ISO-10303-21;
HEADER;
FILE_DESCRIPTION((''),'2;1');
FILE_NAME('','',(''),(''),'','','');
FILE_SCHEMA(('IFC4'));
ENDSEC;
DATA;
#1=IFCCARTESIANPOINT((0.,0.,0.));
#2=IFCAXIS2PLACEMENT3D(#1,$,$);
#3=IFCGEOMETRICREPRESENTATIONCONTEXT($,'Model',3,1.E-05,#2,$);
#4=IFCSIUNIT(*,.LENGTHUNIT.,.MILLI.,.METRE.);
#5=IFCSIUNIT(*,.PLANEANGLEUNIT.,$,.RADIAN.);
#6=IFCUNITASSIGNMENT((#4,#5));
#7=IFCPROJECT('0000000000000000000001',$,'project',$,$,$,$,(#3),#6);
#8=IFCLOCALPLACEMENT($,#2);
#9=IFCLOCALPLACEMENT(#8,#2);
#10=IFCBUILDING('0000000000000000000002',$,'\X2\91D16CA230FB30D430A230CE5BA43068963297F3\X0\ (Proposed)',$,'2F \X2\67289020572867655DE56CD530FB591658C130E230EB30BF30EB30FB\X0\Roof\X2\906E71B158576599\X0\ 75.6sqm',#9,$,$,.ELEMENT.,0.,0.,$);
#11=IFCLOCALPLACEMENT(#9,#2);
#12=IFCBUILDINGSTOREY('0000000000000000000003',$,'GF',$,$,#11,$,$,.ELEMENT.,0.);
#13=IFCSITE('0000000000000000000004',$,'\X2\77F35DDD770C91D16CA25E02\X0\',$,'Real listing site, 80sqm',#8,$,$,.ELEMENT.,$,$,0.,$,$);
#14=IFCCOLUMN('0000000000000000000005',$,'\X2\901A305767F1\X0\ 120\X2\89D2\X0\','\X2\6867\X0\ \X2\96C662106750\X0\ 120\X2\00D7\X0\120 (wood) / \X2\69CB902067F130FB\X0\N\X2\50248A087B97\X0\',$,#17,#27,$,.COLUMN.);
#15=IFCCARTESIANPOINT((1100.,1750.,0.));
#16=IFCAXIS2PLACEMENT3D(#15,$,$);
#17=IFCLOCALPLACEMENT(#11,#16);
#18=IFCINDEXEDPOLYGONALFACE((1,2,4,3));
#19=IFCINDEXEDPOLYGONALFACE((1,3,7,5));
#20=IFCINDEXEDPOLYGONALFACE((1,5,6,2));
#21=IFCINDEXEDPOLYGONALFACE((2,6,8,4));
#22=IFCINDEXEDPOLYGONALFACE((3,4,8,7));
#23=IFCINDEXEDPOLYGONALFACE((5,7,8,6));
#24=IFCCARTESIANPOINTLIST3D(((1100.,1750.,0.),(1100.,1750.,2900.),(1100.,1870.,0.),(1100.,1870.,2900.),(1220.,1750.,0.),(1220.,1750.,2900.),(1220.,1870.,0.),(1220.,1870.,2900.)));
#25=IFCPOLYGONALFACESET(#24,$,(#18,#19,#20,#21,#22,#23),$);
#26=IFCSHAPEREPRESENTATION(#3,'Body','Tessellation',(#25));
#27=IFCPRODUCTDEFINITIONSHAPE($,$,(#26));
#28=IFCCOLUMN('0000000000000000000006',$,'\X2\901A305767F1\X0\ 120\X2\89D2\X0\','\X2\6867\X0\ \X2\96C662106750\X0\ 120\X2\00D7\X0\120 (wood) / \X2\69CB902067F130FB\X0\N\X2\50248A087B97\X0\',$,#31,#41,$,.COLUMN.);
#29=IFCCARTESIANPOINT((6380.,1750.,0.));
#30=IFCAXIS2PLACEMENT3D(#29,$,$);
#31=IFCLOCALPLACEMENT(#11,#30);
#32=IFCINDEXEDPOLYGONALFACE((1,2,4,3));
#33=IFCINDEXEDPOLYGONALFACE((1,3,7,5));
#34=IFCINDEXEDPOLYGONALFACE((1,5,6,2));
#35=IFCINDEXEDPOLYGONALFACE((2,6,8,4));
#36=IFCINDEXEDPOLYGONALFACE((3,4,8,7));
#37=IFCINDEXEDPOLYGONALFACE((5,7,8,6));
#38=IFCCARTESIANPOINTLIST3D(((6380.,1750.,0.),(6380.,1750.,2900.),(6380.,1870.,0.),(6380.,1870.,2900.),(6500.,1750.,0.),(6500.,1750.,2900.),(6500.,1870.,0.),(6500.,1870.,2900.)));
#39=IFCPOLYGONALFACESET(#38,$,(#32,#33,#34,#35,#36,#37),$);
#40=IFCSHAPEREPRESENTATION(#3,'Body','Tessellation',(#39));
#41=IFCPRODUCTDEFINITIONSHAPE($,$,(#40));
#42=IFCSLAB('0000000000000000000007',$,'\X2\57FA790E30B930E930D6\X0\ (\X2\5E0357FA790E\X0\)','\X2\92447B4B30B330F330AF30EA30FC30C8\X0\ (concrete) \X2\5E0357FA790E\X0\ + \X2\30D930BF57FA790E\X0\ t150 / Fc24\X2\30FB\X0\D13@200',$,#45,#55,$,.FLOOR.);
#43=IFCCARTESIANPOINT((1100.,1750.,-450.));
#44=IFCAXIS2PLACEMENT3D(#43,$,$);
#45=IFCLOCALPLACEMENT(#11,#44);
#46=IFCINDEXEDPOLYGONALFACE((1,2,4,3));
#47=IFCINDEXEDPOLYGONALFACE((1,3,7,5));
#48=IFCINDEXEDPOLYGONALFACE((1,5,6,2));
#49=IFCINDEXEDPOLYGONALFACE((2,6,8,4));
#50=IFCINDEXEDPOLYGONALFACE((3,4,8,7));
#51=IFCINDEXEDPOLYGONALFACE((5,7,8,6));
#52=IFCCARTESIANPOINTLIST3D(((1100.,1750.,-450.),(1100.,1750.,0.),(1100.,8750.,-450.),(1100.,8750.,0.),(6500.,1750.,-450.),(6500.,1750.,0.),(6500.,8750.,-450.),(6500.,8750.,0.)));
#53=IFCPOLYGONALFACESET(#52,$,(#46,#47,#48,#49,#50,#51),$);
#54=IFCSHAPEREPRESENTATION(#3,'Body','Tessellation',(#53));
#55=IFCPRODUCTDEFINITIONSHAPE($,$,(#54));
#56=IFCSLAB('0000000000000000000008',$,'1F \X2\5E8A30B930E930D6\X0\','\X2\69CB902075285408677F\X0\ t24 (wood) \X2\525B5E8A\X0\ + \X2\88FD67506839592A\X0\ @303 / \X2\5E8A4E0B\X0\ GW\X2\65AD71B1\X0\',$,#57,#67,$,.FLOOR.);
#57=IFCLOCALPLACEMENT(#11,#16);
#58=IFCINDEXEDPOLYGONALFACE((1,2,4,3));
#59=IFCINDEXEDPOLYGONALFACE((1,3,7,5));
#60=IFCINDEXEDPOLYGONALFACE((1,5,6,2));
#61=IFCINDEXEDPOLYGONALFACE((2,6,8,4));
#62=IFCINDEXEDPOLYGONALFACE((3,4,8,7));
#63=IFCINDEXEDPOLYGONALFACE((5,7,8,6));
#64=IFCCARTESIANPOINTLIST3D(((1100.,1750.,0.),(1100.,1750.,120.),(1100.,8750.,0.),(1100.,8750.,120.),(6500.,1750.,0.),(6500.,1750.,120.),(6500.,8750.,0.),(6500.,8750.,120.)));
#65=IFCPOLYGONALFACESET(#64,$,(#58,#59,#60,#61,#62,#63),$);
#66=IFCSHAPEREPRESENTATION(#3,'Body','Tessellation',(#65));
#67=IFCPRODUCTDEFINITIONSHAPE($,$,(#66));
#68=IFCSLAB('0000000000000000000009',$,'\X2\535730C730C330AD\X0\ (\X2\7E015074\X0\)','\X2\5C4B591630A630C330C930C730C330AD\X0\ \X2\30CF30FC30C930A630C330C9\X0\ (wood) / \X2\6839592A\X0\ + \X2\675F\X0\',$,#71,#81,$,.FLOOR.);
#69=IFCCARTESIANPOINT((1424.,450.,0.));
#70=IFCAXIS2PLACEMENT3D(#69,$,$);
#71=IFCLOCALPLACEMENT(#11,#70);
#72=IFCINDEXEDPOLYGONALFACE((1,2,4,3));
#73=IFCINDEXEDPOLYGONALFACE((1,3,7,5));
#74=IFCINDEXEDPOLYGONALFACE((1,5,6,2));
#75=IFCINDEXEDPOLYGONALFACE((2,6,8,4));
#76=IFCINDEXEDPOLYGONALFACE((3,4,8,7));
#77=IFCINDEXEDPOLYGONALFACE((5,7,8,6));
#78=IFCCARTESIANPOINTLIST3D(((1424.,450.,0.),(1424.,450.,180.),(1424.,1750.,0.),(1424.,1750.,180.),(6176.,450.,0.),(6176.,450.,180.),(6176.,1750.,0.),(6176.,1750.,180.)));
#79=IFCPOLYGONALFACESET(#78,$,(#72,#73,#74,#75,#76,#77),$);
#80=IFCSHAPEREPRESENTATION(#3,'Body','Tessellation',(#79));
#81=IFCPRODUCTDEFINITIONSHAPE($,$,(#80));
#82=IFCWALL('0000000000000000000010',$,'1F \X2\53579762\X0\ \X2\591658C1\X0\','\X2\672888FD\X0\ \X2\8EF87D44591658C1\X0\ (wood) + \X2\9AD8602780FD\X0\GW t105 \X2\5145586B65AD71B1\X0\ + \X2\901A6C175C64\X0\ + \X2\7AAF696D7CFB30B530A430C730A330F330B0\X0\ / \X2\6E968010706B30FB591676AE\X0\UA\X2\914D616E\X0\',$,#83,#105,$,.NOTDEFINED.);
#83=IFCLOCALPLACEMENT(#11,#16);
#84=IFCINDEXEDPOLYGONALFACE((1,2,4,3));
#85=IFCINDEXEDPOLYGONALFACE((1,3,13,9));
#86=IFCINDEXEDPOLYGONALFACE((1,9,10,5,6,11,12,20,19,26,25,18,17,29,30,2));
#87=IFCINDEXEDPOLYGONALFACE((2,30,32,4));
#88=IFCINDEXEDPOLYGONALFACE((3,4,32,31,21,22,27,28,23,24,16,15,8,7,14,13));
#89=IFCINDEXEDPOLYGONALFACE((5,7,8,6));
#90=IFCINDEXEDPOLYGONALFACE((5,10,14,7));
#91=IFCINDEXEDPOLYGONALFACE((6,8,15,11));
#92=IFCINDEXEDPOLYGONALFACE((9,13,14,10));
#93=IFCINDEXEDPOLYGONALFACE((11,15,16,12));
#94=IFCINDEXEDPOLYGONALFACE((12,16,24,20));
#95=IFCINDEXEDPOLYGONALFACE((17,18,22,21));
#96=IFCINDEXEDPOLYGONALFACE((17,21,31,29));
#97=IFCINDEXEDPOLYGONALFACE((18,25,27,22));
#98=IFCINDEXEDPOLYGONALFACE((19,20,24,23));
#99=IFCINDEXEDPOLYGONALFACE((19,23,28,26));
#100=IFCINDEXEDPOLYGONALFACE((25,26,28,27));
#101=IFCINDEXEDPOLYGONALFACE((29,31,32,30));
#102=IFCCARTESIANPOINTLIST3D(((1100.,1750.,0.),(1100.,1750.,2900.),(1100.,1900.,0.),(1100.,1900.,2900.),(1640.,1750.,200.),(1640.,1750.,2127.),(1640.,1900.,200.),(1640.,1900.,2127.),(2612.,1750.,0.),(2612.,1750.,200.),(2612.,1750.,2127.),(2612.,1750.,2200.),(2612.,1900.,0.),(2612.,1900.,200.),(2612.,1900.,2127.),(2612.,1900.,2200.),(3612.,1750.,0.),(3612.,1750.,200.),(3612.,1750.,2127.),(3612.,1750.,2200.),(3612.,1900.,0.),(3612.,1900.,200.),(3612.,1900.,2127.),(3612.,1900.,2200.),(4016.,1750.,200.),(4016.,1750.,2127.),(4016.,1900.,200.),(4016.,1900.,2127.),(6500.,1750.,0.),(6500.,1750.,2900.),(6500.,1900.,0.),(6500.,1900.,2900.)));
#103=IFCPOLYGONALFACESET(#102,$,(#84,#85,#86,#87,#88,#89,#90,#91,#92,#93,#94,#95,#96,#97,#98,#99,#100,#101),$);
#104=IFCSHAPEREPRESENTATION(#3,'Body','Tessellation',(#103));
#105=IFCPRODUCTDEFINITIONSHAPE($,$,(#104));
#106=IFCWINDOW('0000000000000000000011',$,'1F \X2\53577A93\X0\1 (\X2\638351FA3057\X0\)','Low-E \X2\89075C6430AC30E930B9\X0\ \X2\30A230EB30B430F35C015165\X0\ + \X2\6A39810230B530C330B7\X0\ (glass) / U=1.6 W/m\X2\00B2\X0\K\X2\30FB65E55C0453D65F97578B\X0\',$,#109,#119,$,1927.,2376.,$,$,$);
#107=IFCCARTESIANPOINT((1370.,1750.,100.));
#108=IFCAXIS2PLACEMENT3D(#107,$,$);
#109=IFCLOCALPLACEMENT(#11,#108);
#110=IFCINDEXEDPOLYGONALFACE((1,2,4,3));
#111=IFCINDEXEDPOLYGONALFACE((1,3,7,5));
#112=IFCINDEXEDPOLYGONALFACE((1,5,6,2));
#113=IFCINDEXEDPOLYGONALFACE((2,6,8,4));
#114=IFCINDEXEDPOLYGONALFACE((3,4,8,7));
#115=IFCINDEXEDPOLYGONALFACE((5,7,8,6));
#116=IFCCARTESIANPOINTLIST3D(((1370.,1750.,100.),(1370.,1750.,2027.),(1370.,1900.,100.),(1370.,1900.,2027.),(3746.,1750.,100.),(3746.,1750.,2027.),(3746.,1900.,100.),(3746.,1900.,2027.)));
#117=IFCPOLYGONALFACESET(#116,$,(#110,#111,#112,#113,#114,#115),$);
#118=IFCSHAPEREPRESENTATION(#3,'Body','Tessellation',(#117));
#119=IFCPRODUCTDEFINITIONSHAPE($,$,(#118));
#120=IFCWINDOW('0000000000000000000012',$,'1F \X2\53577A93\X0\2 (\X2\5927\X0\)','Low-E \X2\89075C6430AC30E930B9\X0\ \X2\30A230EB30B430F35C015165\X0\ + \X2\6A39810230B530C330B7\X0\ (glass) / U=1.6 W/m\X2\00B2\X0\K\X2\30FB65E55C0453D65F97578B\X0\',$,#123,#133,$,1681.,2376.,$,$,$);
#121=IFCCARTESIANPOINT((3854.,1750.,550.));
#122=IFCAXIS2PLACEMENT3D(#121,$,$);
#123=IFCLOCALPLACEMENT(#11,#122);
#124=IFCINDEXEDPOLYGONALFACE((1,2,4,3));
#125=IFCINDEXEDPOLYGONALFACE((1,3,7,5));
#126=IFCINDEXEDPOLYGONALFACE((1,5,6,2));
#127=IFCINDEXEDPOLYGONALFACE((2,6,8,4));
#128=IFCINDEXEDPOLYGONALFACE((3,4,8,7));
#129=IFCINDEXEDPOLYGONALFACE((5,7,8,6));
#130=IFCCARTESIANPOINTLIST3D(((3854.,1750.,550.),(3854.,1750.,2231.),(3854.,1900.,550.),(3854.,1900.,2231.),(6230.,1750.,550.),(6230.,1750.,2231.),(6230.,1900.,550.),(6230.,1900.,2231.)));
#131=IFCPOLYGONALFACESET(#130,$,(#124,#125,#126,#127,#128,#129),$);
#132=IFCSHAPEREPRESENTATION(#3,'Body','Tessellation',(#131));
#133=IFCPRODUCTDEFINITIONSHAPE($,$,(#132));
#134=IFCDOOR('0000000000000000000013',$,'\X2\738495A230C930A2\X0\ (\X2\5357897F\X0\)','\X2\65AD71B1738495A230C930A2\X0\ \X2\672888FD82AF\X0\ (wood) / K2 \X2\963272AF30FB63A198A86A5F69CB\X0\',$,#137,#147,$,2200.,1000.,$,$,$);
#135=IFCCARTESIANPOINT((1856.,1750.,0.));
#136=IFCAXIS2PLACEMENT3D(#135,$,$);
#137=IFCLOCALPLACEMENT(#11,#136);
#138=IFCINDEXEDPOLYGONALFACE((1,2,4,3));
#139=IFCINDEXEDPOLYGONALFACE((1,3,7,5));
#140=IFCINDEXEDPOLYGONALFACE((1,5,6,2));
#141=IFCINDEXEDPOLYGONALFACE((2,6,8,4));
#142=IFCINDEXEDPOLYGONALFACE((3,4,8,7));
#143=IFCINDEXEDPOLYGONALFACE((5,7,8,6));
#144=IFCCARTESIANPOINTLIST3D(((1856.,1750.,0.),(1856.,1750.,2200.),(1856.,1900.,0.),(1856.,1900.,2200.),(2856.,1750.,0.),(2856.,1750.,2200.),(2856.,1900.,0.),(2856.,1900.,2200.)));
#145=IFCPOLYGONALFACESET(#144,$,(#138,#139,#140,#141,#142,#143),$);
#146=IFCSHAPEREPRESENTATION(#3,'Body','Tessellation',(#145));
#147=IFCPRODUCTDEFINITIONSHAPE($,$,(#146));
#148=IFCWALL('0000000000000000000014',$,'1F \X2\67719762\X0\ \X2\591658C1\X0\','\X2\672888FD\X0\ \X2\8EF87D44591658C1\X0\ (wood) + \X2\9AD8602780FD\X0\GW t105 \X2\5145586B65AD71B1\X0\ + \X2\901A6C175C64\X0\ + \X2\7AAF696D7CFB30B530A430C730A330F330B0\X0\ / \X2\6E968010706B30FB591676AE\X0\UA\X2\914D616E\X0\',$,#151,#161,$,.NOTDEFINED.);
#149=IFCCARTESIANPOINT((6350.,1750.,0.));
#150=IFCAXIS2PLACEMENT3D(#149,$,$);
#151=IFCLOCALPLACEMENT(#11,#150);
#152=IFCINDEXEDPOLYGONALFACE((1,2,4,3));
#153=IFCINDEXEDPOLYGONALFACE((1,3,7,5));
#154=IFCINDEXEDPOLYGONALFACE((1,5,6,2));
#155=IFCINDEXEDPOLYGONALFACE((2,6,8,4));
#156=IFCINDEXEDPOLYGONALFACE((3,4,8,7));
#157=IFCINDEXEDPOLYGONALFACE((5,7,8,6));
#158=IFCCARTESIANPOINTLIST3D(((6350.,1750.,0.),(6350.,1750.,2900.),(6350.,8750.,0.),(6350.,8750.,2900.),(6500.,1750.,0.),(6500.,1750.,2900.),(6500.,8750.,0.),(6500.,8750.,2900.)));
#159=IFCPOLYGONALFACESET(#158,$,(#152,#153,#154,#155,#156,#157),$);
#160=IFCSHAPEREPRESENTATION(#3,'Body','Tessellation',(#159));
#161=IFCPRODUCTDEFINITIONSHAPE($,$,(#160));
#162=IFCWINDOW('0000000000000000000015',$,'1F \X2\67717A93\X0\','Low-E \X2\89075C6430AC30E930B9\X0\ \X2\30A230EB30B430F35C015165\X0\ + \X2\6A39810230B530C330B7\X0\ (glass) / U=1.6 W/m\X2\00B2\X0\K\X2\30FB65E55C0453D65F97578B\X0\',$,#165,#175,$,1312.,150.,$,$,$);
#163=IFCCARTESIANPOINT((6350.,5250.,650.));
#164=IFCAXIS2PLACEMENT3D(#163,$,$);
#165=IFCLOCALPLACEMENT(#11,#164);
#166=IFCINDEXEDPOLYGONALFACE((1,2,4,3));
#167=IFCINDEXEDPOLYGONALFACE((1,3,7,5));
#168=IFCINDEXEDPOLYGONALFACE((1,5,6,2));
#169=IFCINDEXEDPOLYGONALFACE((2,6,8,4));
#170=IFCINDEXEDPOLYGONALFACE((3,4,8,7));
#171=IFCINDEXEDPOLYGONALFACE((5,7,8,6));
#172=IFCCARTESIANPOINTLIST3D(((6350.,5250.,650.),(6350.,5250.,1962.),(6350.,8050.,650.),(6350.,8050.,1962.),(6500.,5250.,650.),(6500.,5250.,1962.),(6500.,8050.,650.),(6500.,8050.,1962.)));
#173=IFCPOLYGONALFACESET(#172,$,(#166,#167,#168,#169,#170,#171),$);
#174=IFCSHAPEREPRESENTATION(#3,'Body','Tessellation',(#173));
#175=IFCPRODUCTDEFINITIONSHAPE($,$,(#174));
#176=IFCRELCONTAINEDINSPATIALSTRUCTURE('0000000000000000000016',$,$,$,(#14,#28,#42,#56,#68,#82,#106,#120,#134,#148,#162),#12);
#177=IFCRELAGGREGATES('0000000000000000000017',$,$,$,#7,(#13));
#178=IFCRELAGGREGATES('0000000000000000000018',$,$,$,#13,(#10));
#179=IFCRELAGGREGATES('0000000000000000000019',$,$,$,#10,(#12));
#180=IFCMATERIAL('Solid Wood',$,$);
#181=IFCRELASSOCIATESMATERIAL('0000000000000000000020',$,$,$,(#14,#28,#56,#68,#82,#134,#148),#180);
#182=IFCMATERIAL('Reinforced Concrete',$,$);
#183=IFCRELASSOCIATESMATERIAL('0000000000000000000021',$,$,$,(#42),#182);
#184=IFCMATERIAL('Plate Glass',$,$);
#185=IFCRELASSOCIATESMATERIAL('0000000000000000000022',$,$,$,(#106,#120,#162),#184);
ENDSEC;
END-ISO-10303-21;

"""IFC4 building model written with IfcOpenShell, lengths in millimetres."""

from ifc_helpers import new_model, si_unit, frame, frame_2d, origin, place, context, project, spatial, rectangle, extrude, material, element, fill, save


model = new_model("IFC4")

# Units and contexts
model_context = context("Model", 3, precision=1e-05, world=origin())
ifc_project = project(units=[si_unit("LENGTHUNIT", "METRE", prefix="MILLI"), si_unit("PLANEANGLEUNIT", "RADIAN")], contexts=[model_context])

# Site, building, storey
site_placement = place(None, origin())
site = spatial("IfcSite", under=ifc_project, at=site_placement, Name="石川県金沢市", ObjectType="Real listing site, 80sqm", CompositionType="ELEMENT", RefElevation=0.0)
building_placement = place(site_placement, origin())
building = spatial("IfcBuilding", under=site, at=building_placement, Name="金沢・ピアノ室と防音 (Proposed)", ObjectType="2F 木造在来工法・外壁モルタル・Roof遮熱塗料 75.6sqm", CompositionType="ELEMENT", ElevationOfRefHeight=0.0, ElevationOfTerrain=0.0)
storey_placement = place(building_placement, origin())
storey = spatial("IfcBuildingStorey", under=building, at=storey_placement, Name="GF", CompositionType="ELEMENT", Elevation=0.0)

# Columns
ifc_material_1 = material(Name="Solid Wood")
column_1_placement = place(storey_placement, frame((1100.0, 1750.0, 0.0)))
element("IfcColumn", 1, at=column_1_placement, inside=storey, material=ifc_material_1, Name="通し柱 120角", Description="桧 集成材 120×120 (wood) / 構造柱・N値計算", PredefinedType="COLUMN", context=model_context, shape_type="SweptSolid", body=[
    extrude(rectangle(XDim=120.0, YDim=120.0, at=frame_2d((60.0, 60.0))), frame((1100.0, 1750.0, 0.0)), (0.0, 0.0, 1.0), 2900.0),
])
column_2_placement = place(storey_placement, frame((6380.0, 1750.0, 0.0)))
element("IfcColumn", 2, at=column_2_placement, inside=storey, material=ifc_material_1, Name="通し柱 120角", Description="桧 集成材 120×120 (wood) / 構造柱・N値計算", PredefinedType="COLUMN", context=model_context, shape_type="SweptSolid", body=[
    extrude(rectangle(XDim=120.0, YDim=120.0, at=frame_2d((60.0, 60.0))), frame((6380.0, 1750.0, 0.0)), (0.0, 0.0, 1.0), 2900.0),
])

# Slabs
ifc_material_2 = material(Name="Reinforced Concrete")
slab_1_placement = place(storey_placement, frame((1100.0, 1750.0, -450.0)))
element("IfcSlab", 3, at=slab_1_placement, inside=storey, material=ifc_material_2, Name="基礎スラブ (布基礎)", Description="鉄筋コンクリート (concrete) 布基礎 + ベタ基礎 t150 / Fc24・D13@200", PredefinedType="FLOOR", context=model_context, shape_type="SweptSolid", body=[
    extrude(rectangle(XDim=5400.0, YDim=7000.0, at=frame_2d((2700.0, 3500.0))), frame((1100.0, 1750.0, -450.0)), (0.0, 0.0, 1.0), 450.0),
])
slab_2_placement = place(storey_placement, frame((1100.0, 1750.0, 0.0)))
element("IfcSlab", 4, at=slab_2_placement, inside=storey, material=ifc_material_1, Name="1F 床スラブ", Description="構造用合板 t24 (wood) 剛床 + 製材根太 @303 / 床下 GW断熱", PredefinedType="FLOOR", context=model_context, shape_type="SweptSolid", body=[
    extrude(rectangle(XDim=5400.0, YDim=7000.0, at=frame_2d((2700.0, 3500.0))), frame((1100.0, 1750.0, 0.0)), (0.0, 0.0, 1.0), 120.0),
])
slab_3_placement = place(storey_placement, frame((1424.0, 450.0, 0.0)))
element("IfcSlab", 5, at=slab_3_placement, inside=storey, material=ifc_material_1, Name="南デッキ (縁側)", Description="屋外ウッドデッキ ハードウッド (wood) / 根太 + 束", PredefinedType="FLOOR", context=model_context, shape_type="SweptSolid", body=[
    extrude(rectangle(XDim=4752.0, YDim=1300.0, at=frame_2d((2376.0, 650.0))), frame((1424.0, 450.0, 0.0)), (0.0, 0.0, 1.0), 180.0),
])

# Wall, openings, windows, door
wall_1_placement = place(storey_placement, frame((1100.0, 1750.0, 0.0)))
wall_1 = element("IfcWall", 6, at=wall_1_placement, inside=storey, material=ifc_material_1, Name="1F 南面 外壁", Description="木製 軸組外壁 (wood) + 高性能GW t105 充填断熱 + 通気層 + 窯業系サイディング / 準耐火・外皮UA配慮", PredefinedType="NOTDEFINED", context=model_context, shape_type="SweptSolid", body=[
    extrude(rectangle(XDim=5400.0, YDim=150.0, at=frame_2d((2700.0, 75.0))), frame((1100.0, 1750.0, 0.0)), (0.0, 0.0, 1.0), 2900.0),
])
opening_1_placement = place(storey_placement, frame((1370.0, 1750.0, 100.0)))
opening_1 = element("IfcOpeningElement", 7, at=opening_1_placement, cuts=wall_1, PredefinedType="NOTDEFINED", context=model_context, shape_type="SweptSolid", body=[
    extrude(rectangle(XDim=2376.0, YDim=150.0, at=frame_2d((1188.0, 75.0))), frame((1370.0, 1750.0, 100.0)), (0.0, 0.0, 1.0), 1927.0),
])
opening_2_placement = place(storey_placement, frame((3854.0, 1750.0, 550.0)))
opening_2 = element("IfcOpeningElement", 8, at=opening_2_placement, cuts=wall_1, PredefinedType="NOTDEFINED", context=model_context, shape_type="SweptSolid", body=[
    extrude(rectangle(XDim=2376.0, YDim=150.0, at=frame_2d((1188.0, 75.0))), frame((3854.0, 1750.0, 550.0)), (0.0, 0.0, 1.0), 1681.0),
])
opening_3_placement = place(storey_placement, frame((1856.0, 1750.0, 0.0)))
opening_3 = element("IfcOpeningElement", 9, at=opening_3_placement, cuts=wall_1, PredefinedType="NOTDEFINED", context=model_context, shape_type="SweptSolid", body=[
    extrude(rectangle(XDim=1000.0, YDim=150.0, at=frame_2d((500.0, 75.0))), frame((1856.0, 1750.0, 0.0)), (0.0, 0.0, 1.0), 2200.0),
])
ifc_material_3 = material(Name="Plate Glass")
window_1_placement = place(storey_placement, frame((1370.0, 1750.0, 100.0)))
window_1 = element("IfcWindow", 10, at=window_1_placement, inside=storey, material=ifc_material_3, Name="1F 南窓1 (掃出し)", Description="Low-E 複層ガラス アルゴン封入 + 樹脂サッシ (glass) / U=1.6 W/m²K・日射取得型", OverallHeight=1927.0, OverallWidth=2376.0, context=model_context, shape_type="SweptSolid", body=[
    extrude(rectangle(XDim=2376.0, YDim=150.0, at=frame_2d((1188.0, 75.0))), frame((1370.0, 1750.0, 100.0)), (0.0, 0.0, 1.0), 1927.0),
])
fill(opening_1, window_1)
window_2_placement = place(storey_placement, frame((3854.0, 1750.0, 550.0)))
window_2 = element("IfcWindow", 11, at=window_2_placement, inside=storey, material=ifc_material_3, Name="1F 南窓2 (大)", Description="Low-E 複層ガラス アルゴン封入 + 樹脂サッシ (glass) / U=1.6 W/m²K・日射取得型", OverallHeight=1681.0, OverallWidth=2376.0, context=model_context, shape_type="SweptSolid", body=[
    extrude(rectangle(XDim=2376.0, YDim=150.0, at=frame_2d((1188.0, 75.0))), frame((3854.0, 1750.0, 550.0)), (0.0, 0.0, 1.0), 1681.0),
])
fill(opening_2, window_2)
door_placement = place(storey_placement, frame((1856.0, 1750.0, 0.0)))
door = element("IfcDoor", 12, at=door_placement, inside=storey, material=ifc_material_1, Name="玄関ドア (南西)", Description="断熱玄関ドア 木製芯 (wood) / K2 防犯・採風機構", OverallHeight=2200.0, OverallWidth=1000.0, context=model_context, shape_type="SweptSolid", body=[
    extrude(rectangle(XDim=1000.0, YDim=150.0, at=frame_2d((500.0, 75.0))), frame((1856.0, 1750.0, 0.0)), (0.0, 0.0, 1.0), 2200.0),
])
fill(opening_3, door)

# Wall, opening, window
wall_2_placement = place(storey_placement, frame((6350.0, 1750.0, 0.0)))
wall_2 = element("IfcWall", 13, at=wall_2_placement, inside=storey, material=ifc_material_1, Name="1F 東面 外壁", Description="木製 軸組外壁 (wood) + 高性能GW t105 充填断熱 + 通気層 + 窯業系サイディング / 準耐火・外皮UA配慮", PredefinedType="NOTDEFINED", context=model_context, shape_type="SweptSolid", body=[
    extrude(rectangle(XDim=150.0, YDim=7000.0, at=frame_2d((75.0, 3500.0))), frame((6350.0, 1750.0, 0.0)), (0.0, 0.0, 1.0), 2900.0),
])
opening_4_placement = place(storey_placement, frame((6350.0, 5250.0, 650.0)))
opening_4 = element("IfcOpeningElement", 14, at=opening_4_placement, cuts=wall_2, PredefinedType="NOTDEFINED", context=model_context, shape_type="SweptSolid", body=[
    extrude(rectangle(XDim=150.0, YDim=2800.0, at=frame_2d((75.0, 1400.0))), frame((6350.0, 5250.0, 650.0)), (0.0, 0.0, 1.0), 1312.0),
])
window_3_placement = place(storey_placement, frame((6350.0, 5250.0, 650.0)))
window_3 = element("IfcWindow", 15, at=window_3_placement, inside=storey, material=ifc_material_3, Name="1F 東窓", Description="Low-E 複層ガラス アルゴン封入 + 樹脂サッシ (glass) / U=1.6 W/m²K・日射取得型", OverallHeight=1312.0, OverallWidth=150.0, context=model_context, shape_type="SweptSolid", body=[
    extrude(rectangle(XDim=150.0, YDim=2800.0, at=frame_2d((75.0, 1400.0))), frame((6350.0, 5250.0, 650.0)), (0.0, 0.0, 1.0), 1312.0),
])
fill(opening_4, window_3)

save(model, "model.ifc")
